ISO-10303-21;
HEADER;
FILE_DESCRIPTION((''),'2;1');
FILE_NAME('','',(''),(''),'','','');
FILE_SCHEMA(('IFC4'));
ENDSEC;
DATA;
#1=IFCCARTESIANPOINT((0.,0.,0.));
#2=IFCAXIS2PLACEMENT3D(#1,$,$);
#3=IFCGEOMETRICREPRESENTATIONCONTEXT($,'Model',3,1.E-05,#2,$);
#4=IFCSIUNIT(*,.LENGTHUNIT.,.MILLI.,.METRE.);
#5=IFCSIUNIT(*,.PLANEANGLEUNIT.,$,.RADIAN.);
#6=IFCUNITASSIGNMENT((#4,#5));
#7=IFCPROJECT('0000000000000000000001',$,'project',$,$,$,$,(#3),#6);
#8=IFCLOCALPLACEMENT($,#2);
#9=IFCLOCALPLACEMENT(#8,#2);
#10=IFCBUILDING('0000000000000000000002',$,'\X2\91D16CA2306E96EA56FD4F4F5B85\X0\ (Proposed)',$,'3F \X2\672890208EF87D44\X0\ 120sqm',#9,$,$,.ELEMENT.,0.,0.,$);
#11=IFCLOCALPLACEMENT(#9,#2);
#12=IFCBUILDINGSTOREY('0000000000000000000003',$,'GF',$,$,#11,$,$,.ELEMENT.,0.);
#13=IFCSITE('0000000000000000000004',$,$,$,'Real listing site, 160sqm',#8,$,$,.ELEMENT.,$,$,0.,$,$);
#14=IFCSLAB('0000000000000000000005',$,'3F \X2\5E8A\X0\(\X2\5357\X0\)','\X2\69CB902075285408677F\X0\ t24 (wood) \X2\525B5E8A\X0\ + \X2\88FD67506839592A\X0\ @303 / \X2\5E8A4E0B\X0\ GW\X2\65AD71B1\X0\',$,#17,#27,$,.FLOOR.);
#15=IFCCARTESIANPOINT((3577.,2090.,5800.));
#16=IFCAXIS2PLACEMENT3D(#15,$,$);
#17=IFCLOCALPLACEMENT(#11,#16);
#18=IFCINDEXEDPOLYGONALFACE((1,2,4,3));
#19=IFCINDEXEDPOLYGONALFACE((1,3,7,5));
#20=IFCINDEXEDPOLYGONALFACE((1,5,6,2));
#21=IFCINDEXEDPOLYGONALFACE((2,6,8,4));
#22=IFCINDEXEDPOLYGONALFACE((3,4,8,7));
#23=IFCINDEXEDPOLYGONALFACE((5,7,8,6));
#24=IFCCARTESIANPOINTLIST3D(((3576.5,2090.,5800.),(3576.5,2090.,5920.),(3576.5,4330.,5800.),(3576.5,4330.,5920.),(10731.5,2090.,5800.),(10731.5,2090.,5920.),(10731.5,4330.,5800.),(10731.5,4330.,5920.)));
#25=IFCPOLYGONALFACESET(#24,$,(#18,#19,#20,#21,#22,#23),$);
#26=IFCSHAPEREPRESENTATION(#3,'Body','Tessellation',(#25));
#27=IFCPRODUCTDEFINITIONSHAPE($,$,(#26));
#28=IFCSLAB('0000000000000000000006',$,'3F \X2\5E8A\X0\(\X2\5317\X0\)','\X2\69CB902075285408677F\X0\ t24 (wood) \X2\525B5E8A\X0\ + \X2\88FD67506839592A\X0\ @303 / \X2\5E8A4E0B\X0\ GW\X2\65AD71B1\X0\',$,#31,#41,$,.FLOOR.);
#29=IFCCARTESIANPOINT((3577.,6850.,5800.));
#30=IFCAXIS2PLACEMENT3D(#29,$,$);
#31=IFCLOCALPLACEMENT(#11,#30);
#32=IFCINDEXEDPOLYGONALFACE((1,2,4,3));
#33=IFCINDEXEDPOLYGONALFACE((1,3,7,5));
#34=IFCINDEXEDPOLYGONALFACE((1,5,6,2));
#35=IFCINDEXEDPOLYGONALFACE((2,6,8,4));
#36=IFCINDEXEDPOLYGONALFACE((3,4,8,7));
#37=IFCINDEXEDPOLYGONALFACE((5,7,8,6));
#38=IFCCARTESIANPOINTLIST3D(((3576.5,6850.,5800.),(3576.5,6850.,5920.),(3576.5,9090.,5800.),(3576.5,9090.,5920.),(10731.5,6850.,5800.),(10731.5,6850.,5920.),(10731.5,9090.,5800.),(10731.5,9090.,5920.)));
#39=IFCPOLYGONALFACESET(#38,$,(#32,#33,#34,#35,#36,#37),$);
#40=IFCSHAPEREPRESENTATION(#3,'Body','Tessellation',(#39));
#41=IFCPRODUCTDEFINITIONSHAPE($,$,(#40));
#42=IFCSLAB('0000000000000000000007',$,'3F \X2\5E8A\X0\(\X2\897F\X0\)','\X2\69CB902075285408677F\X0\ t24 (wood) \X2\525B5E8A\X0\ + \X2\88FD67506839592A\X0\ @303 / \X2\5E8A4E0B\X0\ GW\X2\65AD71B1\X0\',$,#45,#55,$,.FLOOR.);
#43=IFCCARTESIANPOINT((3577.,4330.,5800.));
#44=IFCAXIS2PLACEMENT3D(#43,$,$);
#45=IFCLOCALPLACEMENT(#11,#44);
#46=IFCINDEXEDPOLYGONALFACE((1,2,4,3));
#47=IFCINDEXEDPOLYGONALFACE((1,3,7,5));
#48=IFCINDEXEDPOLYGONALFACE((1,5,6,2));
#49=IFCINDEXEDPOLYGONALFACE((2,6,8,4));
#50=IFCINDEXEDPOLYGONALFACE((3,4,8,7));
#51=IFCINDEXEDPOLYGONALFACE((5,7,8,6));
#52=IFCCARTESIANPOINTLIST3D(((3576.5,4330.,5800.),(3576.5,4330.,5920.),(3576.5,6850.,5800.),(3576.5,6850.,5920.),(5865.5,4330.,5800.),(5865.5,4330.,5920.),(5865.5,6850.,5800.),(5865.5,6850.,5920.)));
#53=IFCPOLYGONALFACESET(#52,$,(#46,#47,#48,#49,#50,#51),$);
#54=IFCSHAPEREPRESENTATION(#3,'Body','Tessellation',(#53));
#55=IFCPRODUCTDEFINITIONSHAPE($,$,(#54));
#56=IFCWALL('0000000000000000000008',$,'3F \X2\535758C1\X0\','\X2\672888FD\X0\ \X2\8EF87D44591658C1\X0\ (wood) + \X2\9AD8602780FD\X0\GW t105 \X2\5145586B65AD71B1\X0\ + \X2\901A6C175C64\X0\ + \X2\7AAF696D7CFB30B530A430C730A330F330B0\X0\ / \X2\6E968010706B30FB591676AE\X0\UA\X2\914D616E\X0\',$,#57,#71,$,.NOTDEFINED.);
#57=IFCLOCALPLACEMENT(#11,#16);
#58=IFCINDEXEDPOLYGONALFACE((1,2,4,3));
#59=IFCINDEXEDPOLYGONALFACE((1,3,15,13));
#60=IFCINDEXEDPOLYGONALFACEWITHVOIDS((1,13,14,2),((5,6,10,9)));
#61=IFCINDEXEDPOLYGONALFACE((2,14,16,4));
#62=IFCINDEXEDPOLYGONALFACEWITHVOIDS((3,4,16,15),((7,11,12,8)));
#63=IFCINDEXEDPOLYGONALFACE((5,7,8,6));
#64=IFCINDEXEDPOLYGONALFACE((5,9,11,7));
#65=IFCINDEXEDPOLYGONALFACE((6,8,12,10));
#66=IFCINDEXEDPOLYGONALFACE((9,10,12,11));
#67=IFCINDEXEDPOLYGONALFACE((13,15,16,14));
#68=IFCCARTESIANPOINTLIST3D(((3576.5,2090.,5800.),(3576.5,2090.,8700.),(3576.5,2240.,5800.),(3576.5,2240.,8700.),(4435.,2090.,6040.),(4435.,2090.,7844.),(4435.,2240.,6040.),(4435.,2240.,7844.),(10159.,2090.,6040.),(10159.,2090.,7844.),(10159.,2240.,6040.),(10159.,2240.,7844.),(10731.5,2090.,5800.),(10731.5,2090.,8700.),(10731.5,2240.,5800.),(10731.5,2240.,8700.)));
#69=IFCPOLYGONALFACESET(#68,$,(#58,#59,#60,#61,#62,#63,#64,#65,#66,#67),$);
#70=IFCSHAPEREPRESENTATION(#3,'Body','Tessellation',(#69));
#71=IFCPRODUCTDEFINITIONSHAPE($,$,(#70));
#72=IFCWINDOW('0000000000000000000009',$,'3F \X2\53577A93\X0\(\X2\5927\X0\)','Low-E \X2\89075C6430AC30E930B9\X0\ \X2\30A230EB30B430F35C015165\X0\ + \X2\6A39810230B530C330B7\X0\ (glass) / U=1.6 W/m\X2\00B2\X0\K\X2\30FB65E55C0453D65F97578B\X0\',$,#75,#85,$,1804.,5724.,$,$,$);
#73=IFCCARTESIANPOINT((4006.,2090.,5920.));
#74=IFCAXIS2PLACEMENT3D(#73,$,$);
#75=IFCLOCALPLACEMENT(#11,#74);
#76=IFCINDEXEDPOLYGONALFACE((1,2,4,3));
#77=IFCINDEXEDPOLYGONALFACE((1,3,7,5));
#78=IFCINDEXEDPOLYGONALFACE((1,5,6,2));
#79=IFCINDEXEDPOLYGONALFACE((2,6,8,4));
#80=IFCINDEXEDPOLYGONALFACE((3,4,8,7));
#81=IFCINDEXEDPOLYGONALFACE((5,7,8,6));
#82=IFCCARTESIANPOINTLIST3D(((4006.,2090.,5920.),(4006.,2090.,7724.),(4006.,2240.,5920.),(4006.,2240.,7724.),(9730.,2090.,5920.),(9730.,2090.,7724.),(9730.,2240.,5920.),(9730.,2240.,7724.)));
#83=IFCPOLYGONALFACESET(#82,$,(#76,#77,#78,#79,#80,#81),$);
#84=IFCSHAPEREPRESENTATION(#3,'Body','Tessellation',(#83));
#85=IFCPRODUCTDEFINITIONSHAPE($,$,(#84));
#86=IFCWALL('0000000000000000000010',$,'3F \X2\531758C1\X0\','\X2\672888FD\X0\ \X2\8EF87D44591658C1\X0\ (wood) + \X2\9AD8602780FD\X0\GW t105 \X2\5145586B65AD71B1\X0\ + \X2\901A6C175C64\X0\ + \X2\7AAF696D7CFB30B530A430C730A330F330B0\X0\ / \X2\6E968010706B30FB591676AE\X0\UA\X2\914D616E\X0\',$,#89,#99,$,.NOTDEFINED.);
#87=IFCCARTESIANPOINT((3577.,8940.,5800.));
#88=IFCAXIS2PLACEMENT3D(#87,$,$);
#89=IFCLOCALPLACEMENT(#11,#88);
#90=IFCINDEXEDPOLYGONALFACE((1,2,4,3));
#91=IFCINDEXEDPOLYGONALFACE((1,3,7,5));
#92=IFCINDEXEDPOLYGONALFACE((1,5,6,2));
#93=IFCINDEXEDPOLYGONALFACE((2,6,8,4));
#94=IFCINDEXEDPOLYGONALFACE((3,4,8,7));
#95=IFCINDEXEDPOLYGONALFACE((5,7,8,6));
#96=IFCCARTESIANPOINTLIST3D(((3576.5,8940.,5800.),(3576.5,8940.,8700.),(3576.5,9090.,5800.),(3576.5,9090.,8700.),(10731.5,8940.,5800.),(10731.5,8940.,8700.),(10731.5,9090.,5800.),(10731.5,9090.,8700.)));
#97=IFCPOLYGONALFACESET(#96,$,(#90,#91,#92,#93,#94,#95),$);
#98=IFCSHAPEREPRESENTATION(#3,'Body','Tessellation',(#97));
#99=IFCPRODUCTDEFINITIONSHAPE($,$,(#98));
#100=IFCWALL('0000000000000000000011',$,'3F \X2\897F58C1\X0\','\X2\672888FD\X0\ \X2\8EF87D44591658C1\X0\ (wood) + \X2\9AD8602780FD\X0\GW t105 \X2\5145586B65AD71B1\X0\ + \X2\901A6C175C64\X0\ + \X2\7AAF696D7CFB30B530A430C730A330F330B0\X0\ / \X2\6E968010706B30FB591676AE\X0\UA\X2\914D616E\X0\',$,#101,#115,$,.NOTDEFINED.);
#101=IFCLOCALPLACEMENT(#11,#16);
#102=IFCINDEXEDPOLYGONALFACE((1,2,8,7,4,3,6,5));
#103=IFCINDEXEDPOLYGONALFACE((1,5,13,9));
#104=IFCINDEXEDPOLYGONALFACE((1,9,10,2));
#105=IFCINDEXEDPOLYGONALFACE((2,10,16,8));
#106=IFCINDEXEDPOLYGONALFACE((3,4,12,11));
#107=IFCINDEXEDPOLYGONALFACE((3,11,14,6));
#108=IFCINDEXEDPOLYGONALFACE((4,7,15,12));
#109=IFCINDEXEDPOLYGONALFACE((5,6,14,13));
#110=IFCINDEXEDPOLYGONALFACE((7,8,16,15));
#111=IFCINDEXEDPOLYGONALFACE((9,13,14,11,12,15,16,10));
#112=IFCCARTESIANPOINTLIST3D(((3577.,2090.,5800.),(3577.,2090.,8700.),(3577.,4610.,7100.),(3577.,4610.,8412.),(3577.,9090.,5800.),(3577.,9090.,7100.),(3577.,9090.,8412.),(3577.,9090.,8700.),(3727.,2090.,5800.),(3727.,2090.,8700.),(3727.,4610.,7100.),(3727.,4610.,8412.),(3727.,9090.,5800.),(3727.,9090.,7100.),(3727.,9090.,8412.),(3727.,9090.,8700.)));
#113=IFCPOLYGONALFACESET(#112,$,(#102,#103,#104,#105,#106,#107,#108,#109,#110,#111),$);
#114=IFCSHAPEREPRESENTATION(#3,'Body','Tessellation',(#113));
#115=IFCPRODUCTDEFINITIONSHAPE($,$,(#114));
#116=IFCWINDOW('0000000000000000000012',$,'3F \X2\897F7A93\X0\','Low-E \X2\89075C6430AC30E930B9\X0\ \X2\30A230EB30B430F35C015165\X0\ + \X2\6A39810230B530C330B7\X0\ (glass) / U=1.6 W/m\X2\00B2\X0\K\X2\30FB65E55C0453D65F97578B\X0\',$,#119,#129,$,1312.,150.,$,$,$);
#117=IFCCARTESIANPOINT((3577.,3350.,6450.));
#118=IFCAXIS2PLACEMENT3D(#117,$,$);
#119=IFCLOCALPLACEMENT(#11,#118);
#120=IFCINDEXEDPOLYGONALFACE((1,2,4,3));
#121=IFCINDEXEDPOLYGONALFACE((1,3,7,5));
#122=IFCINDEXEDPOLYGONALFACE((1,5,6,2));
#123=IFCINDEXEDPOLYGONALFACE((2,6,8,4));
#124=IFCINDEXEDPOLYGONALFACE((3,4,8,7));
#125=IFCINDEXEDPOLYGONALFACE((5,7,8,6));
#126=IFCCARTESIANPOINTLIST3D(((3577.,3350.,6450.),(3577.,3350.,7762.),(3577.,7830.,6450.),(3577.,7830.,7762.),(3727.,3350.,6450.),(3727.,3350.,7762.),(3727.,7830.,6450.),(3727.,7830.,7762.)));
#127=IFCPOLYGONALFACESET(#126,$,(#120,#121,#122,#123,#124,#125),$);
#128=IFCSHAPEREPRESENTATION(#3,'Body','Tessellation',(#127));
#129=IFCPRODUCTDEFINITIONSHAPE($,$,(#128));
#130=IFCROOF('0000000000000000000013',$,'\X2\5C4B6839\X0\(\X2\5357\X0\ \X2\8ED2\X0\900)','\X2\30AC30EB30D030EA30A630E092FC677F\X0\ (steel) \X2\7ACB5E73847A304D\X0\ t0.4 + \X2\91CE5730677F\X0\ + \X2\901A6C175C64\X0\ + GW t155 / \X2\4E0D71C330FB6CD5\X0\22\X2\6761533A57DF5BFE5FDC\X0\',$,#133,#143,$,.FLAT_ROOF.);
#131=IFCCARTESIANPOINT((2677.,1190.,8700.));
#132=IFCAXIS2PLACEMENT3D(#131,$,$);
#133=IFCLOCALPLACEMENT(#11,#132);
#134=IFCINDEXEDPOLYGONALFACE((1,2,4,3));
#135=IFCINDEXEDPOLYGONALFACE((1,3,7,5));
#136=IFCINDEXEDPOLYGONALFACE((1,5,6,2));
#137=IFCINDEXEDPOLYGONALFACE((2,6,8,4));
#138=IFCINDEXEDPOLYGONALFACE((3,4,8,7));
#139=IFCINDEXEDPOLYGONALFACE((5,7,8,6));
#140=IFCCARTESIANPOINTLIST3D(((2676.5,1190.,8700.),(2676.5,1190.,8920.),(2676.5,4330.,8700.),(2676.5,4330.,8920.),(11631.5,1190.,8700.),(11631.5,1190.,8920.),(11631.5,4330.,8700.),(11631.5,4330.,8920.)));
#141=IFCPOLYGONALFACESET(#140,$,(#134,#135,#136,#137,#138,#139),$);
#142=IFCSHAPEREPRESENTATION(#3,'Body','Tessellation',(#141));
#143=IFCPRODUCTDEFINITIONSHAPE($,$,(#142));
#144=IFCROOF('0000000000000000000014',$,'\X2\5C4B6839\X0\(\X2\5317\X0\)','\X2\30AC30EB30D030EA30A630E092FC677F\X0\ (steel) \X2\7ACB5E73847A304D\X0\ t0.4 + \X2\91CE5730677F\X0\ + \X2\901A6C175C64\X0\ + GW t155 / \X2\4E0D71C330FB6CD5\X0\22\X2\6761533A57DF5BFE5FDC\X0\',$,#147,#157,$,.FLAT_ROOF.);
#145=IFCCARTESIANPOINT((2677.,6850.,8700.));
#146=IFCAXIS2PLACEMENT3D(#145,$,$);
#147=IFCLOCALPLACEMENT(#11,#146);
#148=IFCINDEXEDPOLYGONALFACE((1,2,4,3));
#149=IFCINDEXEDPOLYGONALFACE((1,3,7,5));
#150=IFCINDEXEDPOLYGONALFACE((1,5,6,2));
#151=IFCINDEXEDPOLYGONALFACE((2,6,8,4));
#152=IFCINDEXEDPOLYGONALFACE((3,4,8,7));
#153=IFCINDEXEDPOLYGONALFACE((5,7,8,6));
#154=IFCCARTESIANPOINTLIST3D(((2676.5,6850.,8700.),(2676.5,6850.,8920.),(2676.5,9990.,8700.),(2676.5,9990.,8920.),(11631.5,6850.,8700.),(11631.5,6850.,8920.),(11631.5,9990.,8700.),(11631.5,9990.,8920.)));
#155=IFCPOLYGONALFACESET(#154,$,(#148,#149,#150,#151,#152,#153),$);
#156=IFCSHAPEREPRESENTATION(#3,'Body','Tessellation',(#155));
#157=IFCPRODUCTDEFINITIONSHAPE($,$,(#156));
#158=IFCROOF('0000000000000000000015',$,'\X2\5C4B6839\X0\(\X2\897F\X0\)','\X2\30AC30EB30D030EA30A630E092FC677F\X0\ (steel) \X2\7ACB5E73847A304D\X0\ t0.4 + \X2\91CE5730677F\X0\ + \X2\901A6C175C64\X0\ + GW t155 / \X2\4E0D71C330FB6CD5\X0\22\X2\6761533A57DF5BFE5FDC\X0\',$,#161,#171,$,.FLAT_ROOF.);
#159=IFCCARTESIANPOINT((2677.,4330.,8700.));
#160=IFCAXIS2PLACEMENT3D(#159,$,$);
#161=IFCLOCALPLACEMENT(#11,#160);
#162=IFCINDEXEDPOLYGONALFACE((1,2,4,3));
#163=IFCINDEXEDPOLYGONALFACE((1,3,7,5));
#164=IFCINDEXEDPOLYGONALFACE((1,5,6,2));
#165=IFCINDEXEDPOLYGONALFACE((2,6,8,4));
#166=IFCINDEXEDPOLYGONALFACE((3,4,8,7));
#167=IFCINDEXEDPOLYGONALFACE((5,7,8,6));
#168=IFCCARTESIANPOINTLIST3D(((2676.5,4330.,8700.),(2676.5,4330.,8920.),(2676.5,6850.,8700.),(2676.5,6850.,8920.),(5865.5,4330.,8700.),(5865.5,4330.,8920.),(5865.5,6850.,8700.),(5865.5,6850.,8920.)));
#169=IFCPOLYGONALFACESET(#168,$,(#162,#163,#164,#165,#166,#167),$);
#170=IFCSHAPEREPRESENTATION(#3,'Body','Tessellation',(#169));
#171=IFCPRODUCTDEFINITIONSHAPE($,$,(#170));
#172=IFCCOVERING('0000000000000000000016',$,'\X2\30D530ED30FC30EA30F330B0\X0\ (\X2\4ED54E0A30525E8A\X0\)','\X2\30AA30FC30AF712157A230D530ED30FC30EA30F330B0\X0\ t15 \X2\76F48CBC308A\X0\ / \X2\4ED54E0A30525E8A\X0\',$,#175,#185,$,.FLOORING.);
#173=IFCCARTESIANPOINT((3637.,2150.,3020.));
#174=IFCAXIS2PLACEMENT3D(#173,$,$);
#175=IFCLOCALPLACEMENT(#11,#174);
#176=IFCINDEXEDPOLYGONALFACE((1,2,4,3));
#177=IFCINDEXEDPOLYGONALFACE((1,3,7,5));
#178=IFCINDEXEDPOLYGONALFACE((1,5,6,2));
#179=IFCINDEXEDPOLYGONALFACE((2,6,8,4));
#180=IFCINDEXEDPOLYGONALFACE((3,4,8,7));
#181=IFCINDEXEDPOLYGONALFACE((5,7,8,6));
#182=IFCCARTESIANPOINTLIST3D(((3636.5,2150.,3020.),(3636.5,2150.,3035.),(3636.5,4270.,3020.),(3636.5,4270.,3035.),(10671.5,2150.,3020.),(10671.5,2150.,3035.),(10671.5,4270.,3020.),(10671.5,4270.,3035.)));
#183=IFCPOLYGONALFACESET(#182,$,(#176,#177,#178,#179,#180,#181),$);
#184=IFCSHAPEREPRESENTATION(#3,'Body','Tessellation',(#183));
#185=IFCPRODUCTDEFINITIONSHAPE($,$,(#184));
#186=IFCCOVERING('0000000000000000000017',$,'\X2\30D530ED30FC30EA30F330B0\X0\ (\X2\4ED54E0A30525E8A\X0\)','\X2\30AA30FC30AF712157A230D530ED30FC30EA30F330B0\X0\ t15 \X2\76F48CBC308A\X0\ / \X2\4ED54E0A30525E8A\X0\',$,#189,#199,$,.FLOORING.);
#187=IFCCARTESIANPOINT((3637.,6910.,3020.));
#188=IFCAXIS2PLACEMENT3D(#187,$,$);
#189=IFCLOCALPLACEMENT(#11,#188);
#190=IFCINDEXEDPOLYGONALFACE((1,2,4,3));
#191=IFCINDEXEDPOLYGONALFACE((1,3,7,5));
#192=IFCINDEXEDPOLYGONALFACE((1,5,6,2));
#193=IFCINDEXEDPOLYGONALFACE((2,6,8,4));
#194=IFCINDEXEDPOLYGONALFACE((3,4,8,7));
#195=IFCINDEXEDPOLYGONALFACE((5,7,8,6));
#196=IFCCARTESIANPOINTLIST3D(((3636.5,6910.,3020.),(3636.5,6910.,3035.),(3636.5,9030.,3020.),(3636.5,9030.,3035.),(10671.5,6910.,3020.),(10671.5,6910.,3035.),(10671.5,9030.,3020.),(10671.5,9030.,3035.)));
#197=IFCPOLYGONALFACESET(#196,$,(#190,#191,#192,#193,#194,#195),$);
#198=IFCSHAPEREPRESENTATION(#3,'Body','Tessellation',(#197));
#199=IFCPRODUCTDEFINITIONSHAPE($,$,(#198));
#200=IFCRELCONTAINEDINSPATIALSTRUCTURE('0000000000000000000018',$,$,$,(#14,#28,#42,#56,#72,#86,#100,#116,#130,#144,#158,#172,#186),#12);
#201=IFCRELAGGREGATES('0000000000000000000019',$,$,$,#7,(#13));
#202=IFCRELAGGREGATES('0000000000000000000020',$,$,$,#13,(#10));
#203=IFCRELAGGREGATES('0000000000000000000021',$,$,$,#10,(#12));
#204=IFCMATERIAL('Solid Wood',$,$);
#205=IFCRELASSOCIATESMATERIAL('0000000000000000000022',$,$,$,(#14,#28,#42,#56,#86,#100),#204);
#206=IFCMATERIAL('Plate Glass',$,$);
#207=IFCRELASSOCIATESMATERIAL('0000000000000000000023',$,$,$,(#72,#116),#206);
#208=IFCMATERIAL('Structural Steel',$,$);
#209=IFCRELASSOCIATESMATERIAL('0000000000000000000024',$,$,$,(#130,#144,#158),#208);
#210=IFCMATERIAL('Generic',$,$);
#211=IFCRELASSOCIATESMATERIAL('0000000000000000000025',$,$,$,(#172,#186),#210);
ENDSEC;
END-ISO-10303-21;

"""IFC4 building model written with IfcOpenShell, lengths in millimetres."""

from ifc_helpers import new_model, si_unit, frame, frame_2d, origin, place, context, project, spatial, rectangle, extrude, material, element, fill, save


model = new_model("IFC4")

# Units and contexts
model_context = context("Model", 3, precision=1e-05, world=origin())
ifc_project = project(units=[si_unit("LENGTHUNIT", "METRE", prefix="MILLI"), si_unit("PLANEANGLEUNIT", "RADIAN")], contexts=[model_context])

# Site, building, storey
site_placement = place(None, origin())
site = spatial("IfcSite", under=ifc_project, at=site_placement, ObjectType="Real listing site, 160sqm", CompositionType="ELEMENT", RefElevation=0.0)
building_placement = place(site_placement, origin())
building = spatial("IfcBuilding", under=site, at=building_placement, Name="金沢の雪国住宅 (Proposed)", ObjectType="3F 木造軸組 120sqm", CompositionType="ELEMENT", ElevationOfRefHeight=0.0, ElevationOfTerrain=0.0)
storey_placement = place(building_placement, origin())
storey = spatial("IfcBuildingStorey", under=building, at=storey_placement, Name="GF", CompositionType="ELEMENT", Elevation=0.0)

# Slabs
ifc_material_1 = material(Name="Solid Wood")
slab_1_placement = place(storey_placement, frame((3577.0, 2090.0, 5800.0)))
element("IfcSlab", 1, at=slab_1_placement, inside=storey, material=ifc_material_1, Name="3F 床(南)", Description="構造用合板 t24 (wood) 剛床 + 製材根太 @303 / 床下 GW断熱", PredefinedType="FLOOR", context=model_context, shape_type="SweptSolid", body=[
    extrude(rectangle(XDim=7155.0, YDim=2240.0, at=frame_2d((3577.0, 1120.0))), frame((3577.0, 2090.0, 5800.0)), (0.0, 0.0, 1.0), 120.0),
])
slab_2_placement = place(storey_placement, frame((3577.0, 6850.0, 5800.0)))
element("IfcSlab", 2, at=slab_2_placement, inside=storey, material=ifc_material_1, Name="3F 床(北)", Description="構造用合板 t24 (wood) 剛床 + 製材根太 @303 / 床下 GW断熱", PredefinedType="FLOOR", context=model_context, shape_type="SweptSolid", body=[
    extrude(rectangle(XDim=7155.0, YDim=2240.0, at=frame_2d((3577.0, 1120.0))), frame((3577.0, 6850.0, 5800.0)), (0.0, 0.0, 1.0), 120.0),
])
slab_3_placement = place(storey_placement, frame((3577.0, 4330.0, 5800.0)))
element("IfcSlab", 3, at=slab_3_placement, inside=storey, material=ifc_material_1, Name="3F 床(西)", Description="構造用合板 t24 (wood) 剛床 + 製材根太 @303 / 床下 GW断熱", PredefinedType="FLOOR", context=model_context, shape_type="SweptSolid", body=[
    extrude(rectangle(XDim=2289.0, YDim=2520.0, at=frame_2d((1144.0, 1260.0))), frame((3577.0, 4330.0, 5800.0)), (0.0, 0.0, 1.0), 120.0),
])

# Wall, opening, window
wall_1_placement = place(storey_placement, frame((3577.0, 2090.0, 5800.0)))
wall_1 = element("IfcWall", 4, at=wall_1_placement, inside=storey, material=ifc_material_1, Name="3F 南壁", Description="木製 軸組外壁 (wood) + 高性能GW t105 充填断熱 + 通気層 + 窯業系サイディング / 準耐火・外皮UA配慮", PredefinedType="NOTDEFINED", context=model_context, shape_type="SweptSolid", body=[
    extrude(rectangle(XDim=7155.0, YDim=150.0, at=frame_2d((3577.0, 75.0))), frame((3577.0, 2090.0, 5800.0)), (0.0, 0.0, 1.0), 2900.0),
])
opening_1_placement = place(storey_placement, frame((4006.0, 2090.0, 5920.0)))
opening_1 = element("IfcOpeningElement", 5, at=opening_1_placement, cuts=wall_1, PredefinedType="NOTDEFINED", context=model_context, shape_type="SweptSolid", body=[
    extrude(rectangle(XDim=5724.0, YDim=150.0, at=frame_2d((2862.0, 75.0))), frame((4006.0, 2090.0, 5920.0)), (0.0, 0.0, 1.0), 1804.0),
])
ifc_material_2 = material(Name="Plate Glass")
window_1_placement = place(storey_placement, frame((4006.0, 2090.0, 5920.0)))
window_1 = element("IfcWindow", 6, at=window_1_placement, inside=storey, material=ifc_material_2, Name="3F 南窓(大)", Description="Low-E 複層ガラス アルゴン封入 + 樹脂サッシ (glass) / U=1.6 W/m²K・日射取得型", OverallHeight=1804.0, OverallWidth=5724.0, context=model_context, shape_type="SweptSolid", body=[
    extrude(rectangle(XDim=5724.0, YDim=150.0, at=frame_2d((2862.0, 75.0))), frame((4006.0, 2090.0, 5920.0)), (0.0, 0.0, 1.0), 1804.0),
])
fill(opening_1, window_1)

# Wall
wall_2_placement = place(storey_placement, frame((3577.0, 8940.0, 5800.0)))
element("IfcWall", 7, at=wall_2_placement, inside=storey, material=ifc_material_1, Name="3F 北壁", Description="木製 軸組外壁 (wood) + 高性能GW t105 充填断熱 + 通気層 + 窯業系サイディング / 準耐火・外皮UA配慮", PredefinedType="NOTDEFINED", context=model_context, shape_type="SweptSolid", body=[
    extrude(rectangle(XDim=7155.0, YDim=150.0, at=frame_2d((3577.0, 75.0))), frame((3577.0, 8940.0, 5800.0)), (0.0, 0.0, 1.0), 2900.0),
])

# Wall, opening, window
wall_3_placement = place(storey_placement, frame((3577.0, 2090.0, 5800.0)))
wall_3 = element("IfcWall", 8, at=wall_3_placement, inside=storey, material=ifc_material_1, Name="3F 西壁", Description="木製 軸組外壁 (wood) + 高性能GW t105 充填断熱 + 通気層 + 窯業系サイディング / 準耐火・外皮UA配慮", PredefinedType="NOTDEFINED", context=model_context, shape_type="SweptSolid", body=[
    extrude(rectangle(XDim=150.0, YDim=7000.0, at=frame_2d((75.0, 3500.0))), frame((3577.0, 2090.0, 5800.0)), (0.0, 0.0, 1.0), 2900.0),
])
opening_2_placement = place(storey_placement, frame((3577.0, 3350.0, 6450.0)))
opening_2 = element("IfcOpeningElement", 9, at=opening_2_placement, cuts=wall_3, PredefinedType="NOTDEFINED", context=model_context, shape_type="SweptSolid", body=[
    extrude(rectangle(XDim=150.0, YDim=4480.0, at=frame_2d((75.0, 2240.0))), frame((3577.0, 3350.0, 6450.0)), (0.0, 0.0, 1.0), 1312.0),
])
window_2_placement = place(storey_placement, frame((3577.0, 3350.0, 6450.0)))
window_2 = element("IfcWindow", 10, at=window_2_placement, inside=storey, material=ifc_material_2, Name="3F 西窓", Description="Low-E 複層ガラス アルゴン封入 + 樹脂サッシ (glass) / U=1.6 W/m²K・日射取得型", OverallHeight=1312.0, OverallWidth=150.0, context=model_context, shape_type="SweptSolid", body=[
    extrude(rectangle(XDim=150.0, YDim=4480.0, at=frame_2d((75.0, 2240.0))), frame((3577.0, 3350.0, 6450.0)), (0.0, 0.0, 1.0), 1312.0),
])
fill(opening_2, window_2)

# Roofs
ifc_material_3 = material(Name="Structural Steel")
roof_1_placement = place(storey_placement, frame((2677.0, 1190.0, 8700.0)))
element("IfcRoof", 11, at=roof_1_placement, inside=storey, material=ifc_material_3, Name="屋根(南 軒900)", Description="ガルバリウム鋼板 (steel) 立平葺き t0.4 + 野地板 + 通気層 + GW t155 / 不燃・法22条区域対応", PredefinedType="FLAT_ROOF", context=model_context, shape_type="SweptSolid", body=[
    extrude(rectangle(XDim=8955.0, YDim=3140.0, at=frame_2d((4477.0, 1570.0))), frame((2677.0, 1190.0, 8700.0)), (0.0, 0.0, 1.0), 220.0),
])
roof_2_placement = place(storey_placement, frame((2677.0, 6850.0, 8700.0)))
element("IfcRoof", 12, at=roof_2_placement, inside=storey, material=ifc_material_3, Name="屋根(北)", Description="ガルバリウム鋼板 (steel) 立平葺き t0.4 + 野地板 + 通気層 + GW t155 / 不燃・法22条区域対応", PredefinedType="FLAT_ROOF", context=model_context, shape_type="SweptSolid", body=[
    extrude(rectangle(XDim=8955.0, YDim=3140.0, at=frame_2d((4477.0, 1570.0))), frame((2677.0, 6850.0, 8700.0)), (0.0, 0.0, 1.0), 220.0),
])
roof_3_placement = place(storey_placement, frame((2677.0, 4330.0, 8700.0)))
element("IfcRoof", 13, at=roof_3_placement, inside=storey, material=ifc_material_3, Name="屋根(西)", Description="ガルバリウム鋼板 (steel) 立平葺き t0.4 + 野地板 + 通気層 + GW t155 / 不燃・法22条区域対応", PredefinedType="FLAT_ROOF", context=model_context, shape_type="SweptSolid", body=[
    extrude(rectangle(XDim=3189.0, YDim=2520.0, at=frame_2d((1594.0, 1260.0))), frame((2677.0, 4330.0, 8700.0)), (0.0, 0.0, 1.0), 220.0),
])

# Coverings
ifc_material_4 = material(Name="Generic")
covering_1_placement = place(storey_placement, frame((3637.0, 2150.0, 3020.0)))
element("IfcCovering", 14, at=covering_1_placement, inside=storey, material=ifc_material_4, Name="フローリング (仕上げ床)", Description="オーク無垢フローリング t15 直貼り / 仕上げ床", PredefinedType="FLOORING", context=model_context, shape_type="SweptSolid", body=[
    extrude(rectangle(XDim=7035.0, YDim=2120.0, at=frame_2d((3517.0, 1060.0))), frame((3637.0, 2150.0, 3020.0)), (0.0, 0.0, 1.0), 15.0),
])
covering_2_placement = place(storey_placement, frame((3637.0, 6910.0, 3020.0)))
element("IfcCovering", 15, at=covering_2_placement, inside=storey, material=ifc_material_4, Name="フローリング (仕上げ床)", Description="オーク無垢フローリング t15 直貼り / 仕上げ床", PredefinedType="FLOORING", context=model_context, shape_type="SweptSolid", body=[
    extrude(rectangle(XDim=7035.0, YDim=2120.0, at=frame_2d((3517.0, 1060.0))), frame((3637.0, 6910.0, 3020.0)), (0.0, 0.0, 1.0), 15.0),
])

save(model, "model.ifc")
